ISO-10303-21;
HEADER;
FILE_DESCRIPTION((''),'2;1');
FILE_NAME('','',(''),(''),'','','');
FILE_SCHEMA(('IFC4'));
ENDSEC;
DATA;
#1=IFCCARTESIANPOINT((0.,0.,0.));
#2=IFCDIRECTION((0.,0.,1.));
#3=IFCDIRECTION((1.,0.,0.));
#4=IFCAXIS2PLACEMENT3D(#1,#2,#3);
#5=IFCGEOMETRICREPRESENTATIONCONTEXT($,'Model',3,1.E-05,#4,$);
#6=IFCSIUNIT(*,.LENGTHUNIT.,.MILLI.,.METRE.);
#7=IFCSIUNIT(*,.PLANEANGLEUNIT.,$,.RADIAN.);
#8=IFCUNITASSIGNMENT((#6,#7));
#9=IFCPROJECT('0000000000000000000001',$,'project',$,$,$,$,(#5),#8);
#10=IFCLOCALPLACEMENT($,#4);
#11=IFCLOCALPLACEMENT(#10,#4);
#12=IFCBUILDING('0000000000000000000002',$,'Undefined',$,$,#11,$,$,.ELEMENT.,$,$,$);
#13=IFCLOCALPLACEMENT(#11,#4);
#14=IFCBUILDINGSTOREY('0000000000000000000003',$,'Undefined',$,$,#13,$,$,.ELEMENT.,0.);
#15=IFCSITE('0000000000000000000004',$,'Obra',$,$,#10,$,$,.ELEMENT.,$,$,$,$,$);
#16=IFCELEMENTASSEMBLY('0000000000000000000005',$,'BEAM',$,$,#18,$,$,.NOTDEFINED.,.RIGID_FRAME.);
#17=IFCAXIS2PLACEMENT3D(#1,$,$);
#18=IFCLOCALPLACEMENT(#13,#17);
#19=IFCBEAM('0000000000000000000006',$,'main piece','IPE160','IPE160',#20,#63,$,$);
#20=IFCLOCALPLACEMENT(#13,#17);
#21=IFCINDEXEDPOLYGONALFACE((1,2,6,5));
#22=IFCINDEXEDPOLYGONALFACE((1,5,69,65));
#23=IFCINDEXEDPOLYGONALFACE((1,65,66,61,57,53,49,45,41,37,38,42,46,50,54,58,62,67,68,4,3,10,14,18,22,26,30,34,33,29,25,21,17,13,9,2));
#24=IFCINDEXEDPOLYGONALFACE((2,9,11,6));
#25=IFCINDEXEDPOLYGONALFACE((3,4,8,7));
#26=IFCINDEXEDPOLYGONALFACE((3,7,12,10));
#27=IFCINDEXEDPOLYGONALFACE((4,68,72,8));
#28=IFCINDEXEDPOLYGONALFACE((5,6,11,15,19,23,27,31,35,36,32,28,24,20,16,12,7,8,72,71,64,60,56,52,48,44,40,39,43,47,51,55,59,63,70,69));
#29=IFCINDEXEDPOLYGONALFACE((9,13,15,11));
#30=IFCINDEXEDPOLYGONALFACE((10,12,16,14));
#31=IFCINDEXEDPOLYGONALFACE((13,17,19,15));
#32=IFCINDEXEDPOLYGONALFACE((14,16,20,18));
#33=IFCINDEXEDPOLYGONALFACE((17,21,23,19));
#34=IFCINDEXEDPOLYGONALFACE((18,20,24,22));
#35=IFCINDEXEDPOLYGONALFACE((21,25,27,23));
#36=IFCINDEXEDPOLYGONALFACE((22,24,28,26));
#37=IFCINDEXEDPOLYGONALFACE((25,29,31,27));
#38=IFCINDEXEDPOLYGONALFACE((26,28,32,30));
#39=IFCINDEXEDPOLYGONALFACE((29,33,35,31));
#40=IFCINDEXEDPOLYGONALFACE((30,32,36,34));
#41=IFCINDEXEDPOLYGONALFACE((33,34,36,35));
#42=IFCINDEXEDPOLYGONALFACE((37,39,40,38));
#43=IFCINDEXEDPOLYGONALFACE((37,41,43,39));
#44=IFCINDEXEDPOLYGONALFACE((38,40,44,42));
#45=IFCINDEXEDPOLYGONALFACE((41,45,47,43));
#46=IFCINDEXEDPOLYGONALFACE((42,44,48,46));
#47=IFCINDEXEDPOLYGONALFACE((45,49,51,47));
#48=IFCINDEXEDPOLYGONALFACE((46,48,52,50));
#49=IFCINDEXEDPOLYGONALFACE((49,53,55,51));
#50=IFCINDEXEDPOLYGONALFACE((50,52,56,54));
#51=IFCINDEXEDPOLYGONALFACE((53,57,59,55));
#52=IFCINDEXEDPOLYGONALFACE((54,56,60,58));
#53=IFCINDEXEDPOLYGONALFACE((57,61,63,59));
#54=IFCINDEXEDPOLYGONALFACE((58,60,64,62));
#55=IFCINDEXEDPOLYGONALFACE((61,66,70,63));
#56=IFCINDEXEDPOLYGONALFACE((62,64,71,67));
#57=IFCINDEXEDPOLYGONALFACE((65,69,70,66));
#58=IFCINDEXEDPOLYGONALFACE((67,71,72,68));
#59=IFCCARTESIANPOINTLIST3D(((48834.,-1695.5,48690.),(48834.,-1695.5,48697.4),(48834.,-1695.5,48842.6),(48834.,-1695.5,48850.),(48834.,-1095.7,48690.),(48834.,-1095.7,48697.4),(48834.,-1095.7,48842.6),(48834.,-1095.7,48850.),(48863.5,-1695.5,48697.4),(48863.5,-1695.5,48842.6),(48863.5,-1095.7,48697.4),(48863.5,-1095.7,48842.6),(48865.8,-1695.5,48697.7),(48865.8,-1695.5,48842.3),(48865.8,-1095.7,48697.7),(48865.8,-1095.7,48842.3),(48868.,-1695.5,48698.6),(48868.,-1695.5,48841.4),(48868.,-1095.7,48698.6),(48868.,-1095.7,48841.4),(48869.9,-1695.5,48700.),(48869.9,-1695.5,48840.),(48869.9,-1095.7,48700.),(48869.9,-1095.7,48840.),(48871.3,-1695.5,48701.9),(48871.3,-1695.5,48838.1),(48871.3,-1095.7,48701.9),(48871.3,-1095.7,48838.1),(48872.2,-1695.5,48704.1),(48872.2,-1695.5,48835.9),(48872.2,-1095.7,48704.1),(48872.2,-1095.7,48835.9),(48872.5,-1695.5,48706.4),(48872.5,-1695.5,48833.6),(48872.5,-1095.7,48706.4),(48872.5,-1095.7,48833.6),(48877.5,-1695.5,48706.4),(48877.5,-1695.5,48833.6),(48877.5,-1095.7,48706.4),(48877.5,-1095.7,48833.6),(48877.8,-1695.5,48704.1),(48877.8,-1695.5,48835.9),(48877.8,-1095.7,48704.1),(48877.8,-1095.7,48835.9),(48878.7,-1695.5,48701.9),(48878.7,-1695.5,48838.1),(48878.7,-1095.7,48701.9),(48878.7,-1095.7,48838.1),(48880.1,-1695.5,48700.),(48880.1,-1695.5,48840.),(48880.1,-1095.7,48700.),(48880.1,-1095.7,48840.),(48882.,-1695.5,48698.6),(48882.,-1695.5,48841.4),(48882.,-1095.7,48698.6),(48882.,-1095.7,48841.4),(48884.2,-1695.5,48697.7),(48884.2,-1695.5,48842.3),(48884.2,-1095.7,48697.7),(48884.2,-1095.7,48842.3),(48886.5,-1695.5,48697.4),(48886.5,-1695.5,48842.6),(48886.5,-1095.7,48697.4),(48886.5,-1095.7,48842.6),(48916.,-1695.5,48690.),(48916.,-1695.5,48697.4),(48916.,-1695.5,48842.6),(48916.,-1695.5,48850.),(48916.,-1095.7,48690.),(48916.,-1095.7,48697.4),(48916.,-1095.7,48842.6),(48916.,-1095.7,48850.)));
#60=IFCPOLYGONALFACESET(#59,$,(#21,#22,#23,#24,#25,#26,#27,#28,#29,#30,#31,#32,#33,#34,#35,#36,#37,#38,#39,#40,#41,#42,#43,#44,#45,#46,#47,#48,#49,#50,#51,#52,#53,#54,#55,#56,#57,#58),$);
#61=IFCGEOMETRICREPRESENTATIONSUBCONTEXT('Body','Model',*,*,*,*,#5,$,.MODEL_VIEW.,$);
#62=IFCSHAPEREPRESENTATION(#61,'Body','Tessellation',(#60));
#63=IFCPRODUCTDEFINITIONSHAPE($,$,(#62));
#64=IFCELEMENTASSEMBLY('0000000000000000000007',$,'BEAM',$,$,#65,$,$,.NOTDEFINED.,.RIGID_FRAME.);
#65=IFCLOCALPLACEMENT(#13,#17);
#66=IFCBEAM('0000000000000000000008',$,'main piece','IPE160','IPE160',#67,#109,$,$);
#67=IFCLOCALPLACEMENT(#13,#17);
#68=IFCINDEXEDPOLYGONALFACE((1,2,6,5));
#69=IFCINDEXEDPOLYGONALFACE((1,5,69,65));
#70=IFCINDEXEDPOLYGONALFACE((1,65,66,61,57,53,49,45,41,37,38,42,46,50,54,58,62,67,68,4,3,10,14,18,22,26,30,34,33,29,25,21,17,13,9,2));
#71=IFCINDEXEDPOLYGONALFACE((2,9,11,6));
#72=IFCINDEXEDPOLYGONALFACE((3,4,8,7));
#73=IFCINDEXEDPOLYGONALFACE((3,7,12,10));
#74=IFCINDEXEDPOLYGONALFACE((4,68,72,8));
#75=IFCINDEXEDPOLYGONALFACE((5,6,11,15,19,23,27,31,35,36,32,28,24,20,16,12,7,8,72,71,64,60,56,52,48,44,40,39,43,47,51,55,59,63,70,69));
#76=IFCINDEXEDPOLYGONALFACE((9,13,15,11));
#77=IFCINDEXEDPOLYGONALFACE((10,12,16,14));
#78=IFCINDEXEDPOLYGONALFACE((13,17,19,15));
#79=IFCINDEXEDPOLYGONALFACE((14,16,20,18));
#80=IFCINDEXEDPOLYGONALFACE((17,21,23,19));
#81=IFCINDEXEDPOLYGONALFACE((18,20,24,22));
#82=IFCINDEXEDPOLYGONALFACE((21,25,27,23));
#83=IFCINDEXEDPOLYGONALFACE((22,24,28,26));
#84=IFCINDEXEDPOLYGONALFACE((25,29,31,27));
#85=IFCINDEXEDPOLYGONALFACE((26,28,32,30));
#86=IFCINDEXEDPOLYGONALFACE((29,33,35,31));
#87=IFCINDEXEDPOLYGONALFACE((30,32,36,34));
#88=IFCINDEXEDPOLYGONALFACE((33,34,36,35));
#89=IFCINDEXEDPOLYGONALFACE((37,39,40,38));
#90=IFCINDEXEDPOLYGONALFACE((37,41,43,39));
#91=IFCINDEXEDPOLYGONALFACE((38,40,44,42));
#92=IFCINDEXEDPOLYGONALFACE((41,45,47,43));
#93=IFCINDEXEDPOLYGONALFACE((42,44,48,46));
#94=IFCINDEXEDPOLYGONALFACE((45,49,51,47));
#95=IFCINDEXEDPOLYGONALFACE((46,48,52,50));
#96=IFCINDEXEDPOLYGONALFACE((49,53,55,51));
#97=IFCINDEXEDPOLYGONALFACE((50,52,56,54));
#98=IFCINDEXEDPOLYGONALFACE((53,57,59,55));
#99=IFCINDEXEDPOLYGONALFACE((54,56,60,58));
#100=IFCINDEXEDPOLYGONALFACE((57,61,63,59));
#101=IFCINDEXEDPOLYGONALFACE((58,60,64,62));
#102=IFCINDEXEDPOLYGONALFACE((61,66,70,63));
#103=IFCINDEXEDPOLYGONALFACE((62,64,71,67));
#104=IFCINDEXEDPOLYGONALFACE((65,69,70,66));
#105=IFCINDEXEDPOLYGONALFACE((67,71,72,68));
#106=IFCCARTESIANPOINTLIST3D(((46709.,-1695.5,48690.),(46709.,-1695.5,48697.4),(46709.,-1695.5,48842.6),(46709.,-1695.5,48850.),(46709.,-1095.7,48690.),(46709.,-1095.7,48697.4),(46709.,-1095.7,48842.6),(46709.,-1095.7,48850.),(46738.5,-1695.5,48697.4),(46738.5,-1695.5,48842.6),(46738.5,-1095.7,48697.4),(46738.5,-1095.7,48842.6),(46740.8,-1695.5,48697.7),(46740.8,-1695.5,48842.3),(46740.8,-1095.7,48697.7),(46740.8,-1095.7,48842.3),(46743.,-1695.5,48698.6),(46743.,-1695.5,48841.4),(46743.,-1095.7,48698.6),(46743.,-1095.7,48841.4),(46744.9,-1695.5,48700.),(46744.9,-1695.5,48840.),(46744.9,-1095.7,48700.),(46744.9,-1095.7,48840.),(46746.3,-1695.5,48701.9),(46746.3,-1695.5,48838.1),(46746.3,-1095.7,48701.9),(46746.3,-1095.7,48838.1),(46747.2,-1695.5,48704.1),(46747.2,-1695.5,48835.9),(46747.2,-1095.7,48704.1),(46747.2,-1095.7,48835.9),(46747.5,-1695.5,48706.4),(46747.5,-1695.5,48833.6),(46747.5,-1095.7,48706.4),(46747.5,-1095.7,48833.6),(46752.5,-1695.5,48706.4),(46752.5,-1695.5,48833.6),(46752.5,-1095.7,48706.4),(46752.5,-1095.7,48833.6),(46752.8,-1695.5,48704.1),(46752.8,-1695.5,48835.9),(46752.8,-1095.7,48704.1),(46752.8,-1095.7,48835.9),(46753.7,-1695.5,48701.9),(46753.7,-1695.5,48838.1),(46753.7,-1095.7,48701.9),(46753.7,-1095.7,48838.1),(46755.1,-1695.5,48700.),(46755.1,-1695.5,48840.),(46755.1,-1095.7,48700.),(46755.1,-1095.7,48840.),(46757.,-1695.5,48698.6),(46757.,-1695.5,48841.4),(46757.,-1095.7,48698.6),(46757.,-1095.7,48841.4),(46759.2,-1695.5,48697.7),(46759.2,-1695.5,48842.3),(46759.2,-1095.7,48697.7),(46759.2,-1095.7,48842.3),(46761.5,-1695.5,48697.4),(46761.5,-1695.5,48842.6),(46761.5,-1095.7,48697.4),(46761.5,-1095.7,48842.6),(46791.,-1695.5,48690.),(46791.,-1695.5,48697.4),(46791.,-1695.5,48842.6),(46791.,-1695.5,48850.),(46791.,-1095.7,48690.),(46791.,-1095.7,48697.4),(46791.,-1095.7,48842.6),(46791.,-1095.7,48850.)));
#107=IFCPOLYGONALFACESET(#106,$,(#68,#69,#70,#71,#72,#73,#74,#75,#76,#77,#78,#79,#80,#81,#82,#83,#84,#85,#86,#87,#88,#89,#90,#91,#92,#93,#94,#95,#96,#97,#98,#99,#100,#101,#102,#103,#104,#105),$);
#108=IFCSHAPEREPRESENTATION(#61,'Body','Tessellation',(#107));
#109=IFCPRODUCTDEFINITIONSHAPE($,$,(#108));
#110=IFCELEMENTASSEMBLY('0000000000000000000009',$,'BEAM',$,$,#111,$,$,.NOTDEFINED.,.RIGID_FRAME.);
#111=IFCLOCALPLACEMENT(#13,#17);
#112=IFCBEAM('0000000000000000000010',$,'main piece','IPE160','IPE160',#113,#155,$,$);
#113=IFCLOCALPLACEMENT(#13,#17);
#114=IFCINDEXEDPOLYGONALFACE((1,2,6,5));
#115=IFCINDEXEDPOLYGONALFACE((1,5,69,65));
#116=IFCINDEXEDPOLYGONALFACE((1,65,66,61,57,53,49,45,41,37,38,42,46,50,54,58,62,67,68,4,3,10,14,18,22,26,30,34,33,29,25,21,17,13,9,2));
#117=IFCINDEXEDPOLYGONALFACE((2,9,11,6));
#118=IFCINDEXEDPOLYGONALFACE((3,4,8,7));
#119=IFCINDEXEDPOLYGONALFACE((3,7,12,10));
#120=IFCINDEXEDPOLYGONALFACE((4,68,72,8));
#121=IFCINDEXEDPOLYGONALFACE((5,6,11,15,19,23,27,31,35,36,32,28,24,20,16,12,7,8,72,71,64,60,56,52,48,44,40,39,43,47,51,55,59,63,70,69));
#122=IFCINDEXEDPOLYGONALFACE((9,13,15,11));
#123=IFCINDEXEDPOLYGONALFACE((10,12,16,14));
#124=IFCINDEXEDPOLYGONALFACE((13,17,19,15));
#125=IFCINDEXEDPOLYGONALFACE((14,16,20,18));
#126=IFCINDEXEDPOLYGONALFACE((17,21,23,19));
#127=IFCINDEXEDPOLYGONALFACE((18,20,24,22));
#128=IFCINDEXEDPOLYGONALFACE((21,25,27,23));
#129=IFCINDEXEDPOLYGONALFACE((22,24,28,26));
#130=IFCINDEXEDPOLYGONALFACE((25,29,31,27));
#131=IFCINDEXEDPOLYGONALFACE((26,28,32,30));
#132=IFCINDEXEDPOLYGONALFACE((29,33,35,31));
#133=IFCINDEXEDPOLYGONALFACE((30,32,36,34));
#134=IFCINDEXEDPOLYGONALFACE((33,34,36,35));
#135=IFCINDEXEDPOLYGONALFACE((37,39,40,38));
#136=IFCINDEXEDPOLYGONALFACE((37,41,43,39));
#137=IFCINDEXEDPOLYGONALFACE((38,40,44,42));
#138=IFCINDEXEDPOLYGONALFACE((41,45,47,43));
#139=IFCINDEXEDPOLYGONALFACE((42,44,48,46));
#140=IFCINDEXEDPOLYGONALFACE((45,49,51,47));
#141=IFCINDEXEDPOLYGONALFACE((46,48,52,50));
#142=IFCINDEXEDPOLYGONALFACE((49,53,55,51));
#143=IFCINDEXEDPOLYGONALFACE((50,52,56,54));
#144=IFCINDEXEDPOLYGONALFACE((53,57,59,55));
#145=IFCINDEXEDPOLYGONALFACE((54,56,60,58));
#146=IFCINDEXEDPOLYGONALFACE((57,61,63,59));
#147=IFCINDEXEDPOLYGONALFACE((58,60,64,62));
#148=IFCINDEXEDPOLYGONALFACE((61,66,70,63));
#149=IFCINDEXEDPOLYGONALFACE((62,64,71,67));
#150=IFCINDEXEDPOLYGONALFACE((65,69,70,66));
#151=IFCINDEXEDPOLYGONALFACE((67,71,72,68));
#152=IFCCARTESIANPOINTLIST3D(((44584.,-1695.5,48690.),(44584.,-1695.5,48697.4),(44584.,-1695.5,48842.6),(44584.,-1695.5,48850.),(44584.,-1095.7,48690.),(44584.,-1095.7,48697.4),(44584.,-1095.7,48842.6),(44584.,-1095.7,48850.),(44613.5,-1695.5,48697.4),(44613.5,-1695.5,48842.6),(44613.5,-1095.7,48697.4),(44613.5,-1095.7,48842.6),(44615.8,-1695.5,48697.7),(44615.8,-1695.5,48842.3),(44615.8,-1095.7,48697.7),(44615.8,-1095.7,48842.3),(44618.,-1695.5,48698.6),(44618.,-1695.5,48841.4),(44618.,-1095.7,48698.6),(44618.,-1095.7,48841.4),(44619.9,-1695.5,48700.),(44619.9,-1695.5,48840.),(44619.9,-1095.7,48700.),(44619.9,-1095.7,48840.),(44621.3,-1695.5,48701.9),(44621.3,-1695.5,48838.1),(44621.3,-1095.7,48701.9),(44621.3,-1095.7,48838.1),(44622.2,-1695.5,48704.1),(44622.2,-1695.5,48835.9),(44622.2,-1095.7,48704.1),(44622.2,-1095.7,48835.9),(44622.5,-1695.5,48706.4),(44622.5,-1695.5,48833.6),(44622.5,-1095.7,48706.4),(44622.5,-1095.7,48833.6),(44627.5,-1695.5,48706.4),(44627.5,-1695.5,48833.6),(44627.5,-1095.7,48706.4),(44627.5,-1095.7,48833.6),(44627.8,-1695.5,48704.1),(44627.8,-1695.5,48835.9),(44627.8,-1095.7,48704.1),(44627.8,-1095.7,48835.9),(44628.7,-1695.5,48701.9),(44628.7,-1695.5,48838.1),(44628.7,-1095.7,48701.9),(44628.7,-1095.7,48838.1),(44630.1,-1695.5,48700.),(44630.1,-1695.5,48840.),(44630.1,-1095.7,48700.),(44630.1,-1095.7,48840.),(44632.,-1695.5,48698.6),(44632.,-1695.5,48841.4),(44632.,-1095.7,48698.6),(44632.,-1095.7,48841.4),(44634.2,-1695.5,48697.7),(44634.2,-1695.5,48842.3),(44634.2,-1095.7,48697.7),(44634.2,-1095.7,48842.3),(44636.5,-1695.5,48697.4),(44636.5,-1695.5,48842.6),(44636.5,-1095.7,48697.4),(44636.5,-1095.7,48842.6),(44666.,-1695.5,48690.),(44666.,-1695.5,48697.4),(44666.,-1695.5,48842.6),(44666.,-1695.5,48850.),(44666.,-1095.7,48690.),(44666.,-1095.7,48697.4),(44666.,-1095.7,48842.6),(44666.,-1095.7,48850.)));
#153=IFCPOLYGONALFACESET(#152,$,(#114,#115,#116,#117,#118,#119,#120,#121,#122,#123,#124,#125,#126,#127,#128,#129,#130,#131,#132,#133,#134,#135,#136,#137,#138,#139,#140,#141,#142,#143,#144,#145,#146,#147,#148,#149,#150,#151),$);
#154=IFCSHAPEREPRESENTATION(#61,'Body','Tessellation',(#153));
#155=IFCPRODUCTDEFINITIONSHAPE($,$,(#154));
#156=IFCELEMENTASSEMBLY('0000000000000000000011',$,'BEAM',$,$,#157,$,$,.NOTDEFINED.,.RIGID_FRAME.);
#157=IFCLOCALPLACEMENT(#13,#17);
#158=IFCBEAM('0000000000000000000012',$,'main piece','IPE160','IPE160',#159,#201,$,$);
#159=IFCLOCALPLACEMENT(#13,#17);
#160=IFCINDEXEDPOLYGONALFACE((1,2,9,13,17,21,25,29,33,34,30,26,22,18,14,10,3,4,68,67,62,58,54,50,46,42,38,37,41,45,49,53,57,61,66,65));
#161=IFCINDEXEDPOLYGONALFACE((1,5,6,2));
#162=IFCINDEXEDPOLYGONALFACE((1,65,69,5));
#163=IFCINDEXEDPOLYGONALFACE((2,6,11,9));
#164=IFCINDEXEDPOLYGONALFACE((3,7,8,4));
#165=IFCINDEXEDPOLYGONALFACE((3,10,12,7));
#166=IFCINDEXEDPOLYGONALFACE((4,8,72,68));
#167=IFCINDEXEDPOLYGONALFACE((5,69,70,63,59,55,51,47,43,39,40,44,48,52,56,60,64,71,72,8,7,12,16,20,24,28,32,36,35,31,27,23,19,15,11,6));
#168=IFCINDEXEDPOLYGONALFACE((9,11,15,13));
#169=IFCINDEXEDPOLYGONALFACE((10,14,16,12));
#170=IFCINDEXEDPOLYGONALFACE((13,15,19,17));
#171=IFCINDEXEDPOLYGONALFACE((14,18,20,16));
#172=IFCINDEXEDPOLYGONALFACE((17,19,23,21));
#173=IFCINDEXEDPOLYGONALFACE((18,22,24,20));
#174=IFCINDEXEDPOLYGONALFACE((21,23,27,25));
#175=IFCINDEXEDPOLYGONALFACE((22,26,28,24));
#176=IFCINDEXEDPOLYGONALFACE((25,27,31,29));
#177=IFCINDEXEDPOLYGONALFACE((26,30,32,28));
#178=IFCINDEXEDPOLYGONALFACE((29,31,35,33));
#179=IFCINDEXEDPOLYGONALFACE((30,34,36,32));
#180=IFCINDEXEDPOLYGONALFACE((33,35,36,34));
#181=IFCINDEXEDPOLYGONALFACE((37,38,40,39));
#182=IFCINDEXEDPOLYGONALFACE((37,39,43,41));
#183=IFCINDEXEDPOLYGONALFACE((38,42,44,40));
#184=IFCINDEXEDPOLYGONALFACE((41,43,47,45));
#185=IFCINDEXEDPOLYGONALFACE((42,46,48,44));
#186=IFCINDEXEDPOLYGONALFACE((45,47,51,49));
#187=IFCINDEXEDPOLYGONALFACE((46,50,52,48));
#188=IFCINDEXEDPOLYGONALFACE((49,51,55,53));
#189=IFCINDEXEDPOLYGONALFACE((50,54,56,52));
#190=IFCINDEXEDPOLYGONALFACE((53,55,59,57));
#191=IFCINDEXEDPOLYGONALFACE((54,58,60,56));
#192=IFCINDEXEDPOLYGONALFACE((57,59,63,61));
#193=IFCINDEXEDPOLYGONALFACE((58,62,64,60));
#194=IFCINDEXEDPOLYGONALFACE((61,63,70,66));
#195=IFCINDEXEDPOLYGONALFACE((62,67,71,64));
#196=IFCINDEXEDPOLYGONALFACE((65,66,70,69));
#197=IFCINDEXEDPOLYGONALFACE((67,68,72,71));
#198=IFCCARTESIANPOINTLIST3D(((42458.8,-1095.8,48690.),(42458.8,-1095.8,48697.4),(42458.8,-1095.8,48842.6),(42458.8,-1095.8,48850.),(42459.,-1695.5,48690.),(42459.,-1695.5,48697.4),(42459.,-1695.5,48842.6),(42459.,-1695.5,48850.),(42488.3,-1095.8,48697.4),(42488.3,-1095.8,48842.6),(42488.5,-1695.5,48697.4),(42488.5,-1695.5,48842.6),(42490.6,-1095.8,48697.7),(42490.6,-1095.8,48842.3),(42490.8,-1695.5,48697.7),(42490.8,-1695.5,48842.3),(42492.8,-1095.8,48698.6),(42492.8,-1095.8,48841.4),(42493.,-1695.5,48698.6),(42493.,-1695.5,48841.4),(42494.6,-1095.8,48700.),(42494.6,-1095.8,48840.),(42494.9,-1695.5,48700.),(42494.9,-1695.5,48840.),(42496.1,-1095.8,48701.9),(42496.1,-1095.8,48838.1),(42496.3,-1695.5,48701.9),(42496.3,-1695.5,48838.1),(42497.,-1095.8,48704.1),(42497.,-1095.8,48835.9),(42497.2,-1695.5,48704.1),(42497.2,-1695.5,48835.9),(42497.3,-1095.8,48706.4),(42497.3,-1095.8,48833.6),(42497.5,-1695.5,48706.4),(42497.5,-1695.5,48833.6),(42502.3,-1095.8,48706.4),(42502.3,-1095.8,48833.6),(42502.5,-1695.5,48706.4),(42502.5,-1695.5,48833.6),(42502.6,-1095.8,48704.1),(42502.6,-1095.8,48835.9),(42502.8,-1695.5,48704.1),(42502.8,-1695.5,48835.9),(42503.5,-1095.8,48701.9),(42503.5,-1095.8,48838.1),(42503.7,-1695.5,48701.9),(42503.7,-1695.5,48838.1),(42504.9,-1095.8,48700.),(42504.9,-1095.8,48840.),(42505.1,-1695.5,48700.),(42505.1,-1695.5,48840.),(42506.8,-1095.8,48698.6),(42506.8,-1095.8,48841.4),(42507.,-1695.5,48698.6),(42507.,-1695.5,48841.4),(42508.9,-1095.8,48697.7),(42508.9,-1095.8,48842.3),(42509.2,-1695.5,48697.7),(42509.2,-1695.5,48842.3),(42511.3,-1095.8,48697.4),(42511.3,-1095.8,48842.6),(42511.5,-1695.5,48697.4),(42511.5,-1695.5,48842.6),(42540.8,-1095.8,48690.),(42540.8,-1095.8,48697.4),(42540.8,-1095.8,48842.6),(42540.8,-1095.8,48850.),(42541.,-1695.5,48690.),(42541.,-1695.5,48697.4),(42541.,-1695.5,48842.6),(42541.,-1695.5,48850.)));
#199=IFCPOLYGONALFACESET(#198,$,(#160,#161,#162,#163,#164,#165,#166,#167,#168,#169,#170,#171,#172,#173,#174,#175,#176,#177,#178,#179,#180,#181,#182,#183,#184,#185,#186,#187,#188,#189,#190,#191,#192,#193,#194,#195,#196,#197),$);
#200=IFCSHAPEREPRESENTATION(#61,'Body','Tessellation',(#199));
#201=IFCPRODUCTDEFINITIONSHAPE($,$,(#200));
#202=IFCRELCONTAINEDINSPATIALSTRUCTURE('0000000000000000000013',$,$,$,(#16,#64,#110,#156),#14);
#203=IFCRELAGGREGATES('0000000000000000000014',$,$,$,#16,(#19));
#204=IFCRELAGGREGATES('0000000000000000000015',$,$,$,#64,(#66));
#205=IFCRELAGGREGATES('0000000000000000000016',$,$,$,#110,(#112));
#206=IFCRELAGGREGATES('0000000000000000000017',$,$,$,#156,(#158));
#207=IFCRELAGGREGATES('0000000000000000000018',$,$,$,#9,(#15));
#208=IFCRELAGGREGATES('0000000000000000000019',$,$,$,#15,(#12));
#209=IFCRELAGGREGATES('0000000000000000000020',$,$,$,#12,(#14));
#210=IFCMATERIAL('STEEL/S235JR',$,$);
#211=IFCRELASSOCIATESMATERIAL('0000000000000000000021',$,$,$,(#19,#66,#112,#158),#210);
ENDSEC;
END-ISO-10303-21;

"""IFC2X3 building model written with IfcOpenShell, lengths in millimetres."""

from ifc_helpers import new_model, si_unit, frame, origin_with_axes, origin_2d_with_axis, place, context, subcontext, project, spatial, i_section, extrude, material, element, aggregate, save


model = new_model("IFC2X3")

# Units and contexts
model_context = context("Model", 3, precision=1e-05, world=origin_with_axes())
body_context = subcontext(model_context, "Body", "Model", "MODEL_VIEW")
ifc_project = project(units=[si_unit("LENGTHUNIT", "METRE", prefix="MILLI"), si_unit("PLANEANGLEUNIT", "RADIAN")], contexts=[model_context])

# Site, building, storey
site_placement = place(None, origin_with_axes())
site = spatial("IfcSite", under=ifc_project, at=site_placement, Name="Obra", CompositionType="ELEMENT")
building_placement = place(site_placement, origin_with_axes())
building = spatial("IfcBuilding", under=site, at=building_placement, Name="Undefined", CompositionType="ELEMENT")
storey_placement = place(building_placement, origin_with_axes())
storey = spatial("IfcBuildingStorey", under=building, at=storey_placement, Name="Undefined", CompositionType="ELEMENT", Elevation=0.0)

# Shared definitions
ifc_material_1 = material(Name="STEEL/S235JR")

# Element assemblies, beams
assembly_1_placement = place(storey_placement, origin_with_axes())
assembly_1 = element("IfcElementAssembly", 1, at=assembly_1_placement, inside=storey, Name="BEAM", AssemblyPlace="NOTDEFINED", PredefinedType="RIGID_FRAME")
beam_1_placement = place(assembly_1_placement, frame((48875.0, -1695.5, 48770.0), z_axis=(0.0, 0.0, 1.0), x_axis=(0.0, 1.0, 0.0)))
beam_1 = element("IfcBeam", 2, at=beam_1_placement, material=ifc_material_1, Name="main piece", Description="IPE160", ObjectType="IPE160", context=body_context, shape_type="SweptSolid", body=[
    extrude(i_section(OverallWidth=82.0, OverallDepth=160.0, WebThickness=5.0, FlangeThickness=7.4, FilletRadius=9.0, at=origin_2d_with_axis()), frame((599.8, 0.0, 0.0), z_axis=(-1.0, 0.0, 0.0), x_axis=(0.0, -1.0, 0.0)), (0.0, 0.0, 1.0), 599.8),
])
aggregate(assembly_1, [beam_1])
assembly_2_placement = place(storey_placement, origin_with_axes())
assembly_2 = element("IfcElementAssembly", 3, at=assembly_2_placement, inside=storey, Name="BEAM", AssemblyPlace="NOTDEFINED", PredefinedType="RIGID_FRAME")
beam_2_placement = place(assembly_2_placement, frame((46750.0, -1095.7, 48770.0), z_axis=(0.0, 0.0, 1.0), x_axis=(0.0, -1.0, 0.0)))
beam_2 = element("IfcBeam", 4, at=beam_2_placement, material=ifc_material_1, Name="main piece", Description="IPE160", ObjectType="IPE160", context=body_context, shape_type="SweptSolid", body=[
    extrude(i_section(OverallWidth=82.0, OverallDepth=160.0, WebThickness=5.0, FlangeThickness=7.4, FilletRadius=9.0, at=origin_2d_with_axis()), frame((599.8, 0.0, 0.0), z_axis=(-1.0, 0.0, 0.0), x_axis=(0.0, -1.0, 0.0)), (0.0, 0.0, 1.0), 599.8),
])
aggregate(assembly_2, [beam_2])
assembly_3_placement = place(storey_placement, origin_with_axes())
assembly_3 = element("IfcElementAssembly", 5, at=assembly_3_placement, inside=storey, Name="BEAM", AssemblyPlace="NOTDEFINED", PredefinedType="RIGID_FRAME")
beam_3_placement = place(assembly_3_placement, frame((44625.0, -1695.5, 48770.0), z_axis=(0.0, 0.0, 1.0), x_axis=(0.0, 1.0, 0.0)))
beam_3 = element("IfcBeam", 6, at=beam_3_placement, material=ifc_material_1, Name="main piece", Description="IPE160", ObjectType="IPE160", context=body_context, shape_type="SweptSolid", body=[
    extrude(i_section(OverallWidth=82.0, OverallDepth=160.0, WebThickness=5.0, FlangeThickness=7.4, FilletRadius=9.0, at=origin_2d_with_axis()), frame((599.8, 0.0, 0.0), z_axis=(-1.0, 0.0, 0.0), x_axis=(0.0, -1.0, 0.0)), (0.0, 0.0, 1.0), 599.8),
])
aggregate(assembly_3, [beam_3])
assembly_4_placement = place(storey_placement, origin_with_axes())
assembly_4 = element("IfcElementAssembly", 7, at=assembly_4_placement, inside=storey, Name="BEAM", AssemblyPlace="NOTDEFINED", PredefinedType="RIGID_FRAME")
beam_4_placement = place(assembly_4_placement, frame((42499.8, -1095.8, 48770.0), z_axis=(0.0, 0.0, 1.0), x_axis=(0.000388, -1.0, 0.0)))
beam_4 = element("IfcBeam", 8, at=beam_4_placement, material=ifc_material_1, Name="main piece", Description="IPE160", ObjectType="IPE160", context=body_context, shape_type="SweptSolid", body=[
    extrude(i_section(OverallWidth=82.0, OverallDepth=160.0, WebThickness=5.0, FlangeThickness=7.4, FilletRadius=9.0, at=origin_2d_with_axis()), frame((599.7, 0.0, 0.0), z_axis=(-1.0, 0.0, 0.0), x_axis=(0.0, -1.0, 0.0)), (0.0, 0.0, 1.0), 599.7),
])
aggregate(assembly_4, [beam_4])

save(model, "model.ifc")
